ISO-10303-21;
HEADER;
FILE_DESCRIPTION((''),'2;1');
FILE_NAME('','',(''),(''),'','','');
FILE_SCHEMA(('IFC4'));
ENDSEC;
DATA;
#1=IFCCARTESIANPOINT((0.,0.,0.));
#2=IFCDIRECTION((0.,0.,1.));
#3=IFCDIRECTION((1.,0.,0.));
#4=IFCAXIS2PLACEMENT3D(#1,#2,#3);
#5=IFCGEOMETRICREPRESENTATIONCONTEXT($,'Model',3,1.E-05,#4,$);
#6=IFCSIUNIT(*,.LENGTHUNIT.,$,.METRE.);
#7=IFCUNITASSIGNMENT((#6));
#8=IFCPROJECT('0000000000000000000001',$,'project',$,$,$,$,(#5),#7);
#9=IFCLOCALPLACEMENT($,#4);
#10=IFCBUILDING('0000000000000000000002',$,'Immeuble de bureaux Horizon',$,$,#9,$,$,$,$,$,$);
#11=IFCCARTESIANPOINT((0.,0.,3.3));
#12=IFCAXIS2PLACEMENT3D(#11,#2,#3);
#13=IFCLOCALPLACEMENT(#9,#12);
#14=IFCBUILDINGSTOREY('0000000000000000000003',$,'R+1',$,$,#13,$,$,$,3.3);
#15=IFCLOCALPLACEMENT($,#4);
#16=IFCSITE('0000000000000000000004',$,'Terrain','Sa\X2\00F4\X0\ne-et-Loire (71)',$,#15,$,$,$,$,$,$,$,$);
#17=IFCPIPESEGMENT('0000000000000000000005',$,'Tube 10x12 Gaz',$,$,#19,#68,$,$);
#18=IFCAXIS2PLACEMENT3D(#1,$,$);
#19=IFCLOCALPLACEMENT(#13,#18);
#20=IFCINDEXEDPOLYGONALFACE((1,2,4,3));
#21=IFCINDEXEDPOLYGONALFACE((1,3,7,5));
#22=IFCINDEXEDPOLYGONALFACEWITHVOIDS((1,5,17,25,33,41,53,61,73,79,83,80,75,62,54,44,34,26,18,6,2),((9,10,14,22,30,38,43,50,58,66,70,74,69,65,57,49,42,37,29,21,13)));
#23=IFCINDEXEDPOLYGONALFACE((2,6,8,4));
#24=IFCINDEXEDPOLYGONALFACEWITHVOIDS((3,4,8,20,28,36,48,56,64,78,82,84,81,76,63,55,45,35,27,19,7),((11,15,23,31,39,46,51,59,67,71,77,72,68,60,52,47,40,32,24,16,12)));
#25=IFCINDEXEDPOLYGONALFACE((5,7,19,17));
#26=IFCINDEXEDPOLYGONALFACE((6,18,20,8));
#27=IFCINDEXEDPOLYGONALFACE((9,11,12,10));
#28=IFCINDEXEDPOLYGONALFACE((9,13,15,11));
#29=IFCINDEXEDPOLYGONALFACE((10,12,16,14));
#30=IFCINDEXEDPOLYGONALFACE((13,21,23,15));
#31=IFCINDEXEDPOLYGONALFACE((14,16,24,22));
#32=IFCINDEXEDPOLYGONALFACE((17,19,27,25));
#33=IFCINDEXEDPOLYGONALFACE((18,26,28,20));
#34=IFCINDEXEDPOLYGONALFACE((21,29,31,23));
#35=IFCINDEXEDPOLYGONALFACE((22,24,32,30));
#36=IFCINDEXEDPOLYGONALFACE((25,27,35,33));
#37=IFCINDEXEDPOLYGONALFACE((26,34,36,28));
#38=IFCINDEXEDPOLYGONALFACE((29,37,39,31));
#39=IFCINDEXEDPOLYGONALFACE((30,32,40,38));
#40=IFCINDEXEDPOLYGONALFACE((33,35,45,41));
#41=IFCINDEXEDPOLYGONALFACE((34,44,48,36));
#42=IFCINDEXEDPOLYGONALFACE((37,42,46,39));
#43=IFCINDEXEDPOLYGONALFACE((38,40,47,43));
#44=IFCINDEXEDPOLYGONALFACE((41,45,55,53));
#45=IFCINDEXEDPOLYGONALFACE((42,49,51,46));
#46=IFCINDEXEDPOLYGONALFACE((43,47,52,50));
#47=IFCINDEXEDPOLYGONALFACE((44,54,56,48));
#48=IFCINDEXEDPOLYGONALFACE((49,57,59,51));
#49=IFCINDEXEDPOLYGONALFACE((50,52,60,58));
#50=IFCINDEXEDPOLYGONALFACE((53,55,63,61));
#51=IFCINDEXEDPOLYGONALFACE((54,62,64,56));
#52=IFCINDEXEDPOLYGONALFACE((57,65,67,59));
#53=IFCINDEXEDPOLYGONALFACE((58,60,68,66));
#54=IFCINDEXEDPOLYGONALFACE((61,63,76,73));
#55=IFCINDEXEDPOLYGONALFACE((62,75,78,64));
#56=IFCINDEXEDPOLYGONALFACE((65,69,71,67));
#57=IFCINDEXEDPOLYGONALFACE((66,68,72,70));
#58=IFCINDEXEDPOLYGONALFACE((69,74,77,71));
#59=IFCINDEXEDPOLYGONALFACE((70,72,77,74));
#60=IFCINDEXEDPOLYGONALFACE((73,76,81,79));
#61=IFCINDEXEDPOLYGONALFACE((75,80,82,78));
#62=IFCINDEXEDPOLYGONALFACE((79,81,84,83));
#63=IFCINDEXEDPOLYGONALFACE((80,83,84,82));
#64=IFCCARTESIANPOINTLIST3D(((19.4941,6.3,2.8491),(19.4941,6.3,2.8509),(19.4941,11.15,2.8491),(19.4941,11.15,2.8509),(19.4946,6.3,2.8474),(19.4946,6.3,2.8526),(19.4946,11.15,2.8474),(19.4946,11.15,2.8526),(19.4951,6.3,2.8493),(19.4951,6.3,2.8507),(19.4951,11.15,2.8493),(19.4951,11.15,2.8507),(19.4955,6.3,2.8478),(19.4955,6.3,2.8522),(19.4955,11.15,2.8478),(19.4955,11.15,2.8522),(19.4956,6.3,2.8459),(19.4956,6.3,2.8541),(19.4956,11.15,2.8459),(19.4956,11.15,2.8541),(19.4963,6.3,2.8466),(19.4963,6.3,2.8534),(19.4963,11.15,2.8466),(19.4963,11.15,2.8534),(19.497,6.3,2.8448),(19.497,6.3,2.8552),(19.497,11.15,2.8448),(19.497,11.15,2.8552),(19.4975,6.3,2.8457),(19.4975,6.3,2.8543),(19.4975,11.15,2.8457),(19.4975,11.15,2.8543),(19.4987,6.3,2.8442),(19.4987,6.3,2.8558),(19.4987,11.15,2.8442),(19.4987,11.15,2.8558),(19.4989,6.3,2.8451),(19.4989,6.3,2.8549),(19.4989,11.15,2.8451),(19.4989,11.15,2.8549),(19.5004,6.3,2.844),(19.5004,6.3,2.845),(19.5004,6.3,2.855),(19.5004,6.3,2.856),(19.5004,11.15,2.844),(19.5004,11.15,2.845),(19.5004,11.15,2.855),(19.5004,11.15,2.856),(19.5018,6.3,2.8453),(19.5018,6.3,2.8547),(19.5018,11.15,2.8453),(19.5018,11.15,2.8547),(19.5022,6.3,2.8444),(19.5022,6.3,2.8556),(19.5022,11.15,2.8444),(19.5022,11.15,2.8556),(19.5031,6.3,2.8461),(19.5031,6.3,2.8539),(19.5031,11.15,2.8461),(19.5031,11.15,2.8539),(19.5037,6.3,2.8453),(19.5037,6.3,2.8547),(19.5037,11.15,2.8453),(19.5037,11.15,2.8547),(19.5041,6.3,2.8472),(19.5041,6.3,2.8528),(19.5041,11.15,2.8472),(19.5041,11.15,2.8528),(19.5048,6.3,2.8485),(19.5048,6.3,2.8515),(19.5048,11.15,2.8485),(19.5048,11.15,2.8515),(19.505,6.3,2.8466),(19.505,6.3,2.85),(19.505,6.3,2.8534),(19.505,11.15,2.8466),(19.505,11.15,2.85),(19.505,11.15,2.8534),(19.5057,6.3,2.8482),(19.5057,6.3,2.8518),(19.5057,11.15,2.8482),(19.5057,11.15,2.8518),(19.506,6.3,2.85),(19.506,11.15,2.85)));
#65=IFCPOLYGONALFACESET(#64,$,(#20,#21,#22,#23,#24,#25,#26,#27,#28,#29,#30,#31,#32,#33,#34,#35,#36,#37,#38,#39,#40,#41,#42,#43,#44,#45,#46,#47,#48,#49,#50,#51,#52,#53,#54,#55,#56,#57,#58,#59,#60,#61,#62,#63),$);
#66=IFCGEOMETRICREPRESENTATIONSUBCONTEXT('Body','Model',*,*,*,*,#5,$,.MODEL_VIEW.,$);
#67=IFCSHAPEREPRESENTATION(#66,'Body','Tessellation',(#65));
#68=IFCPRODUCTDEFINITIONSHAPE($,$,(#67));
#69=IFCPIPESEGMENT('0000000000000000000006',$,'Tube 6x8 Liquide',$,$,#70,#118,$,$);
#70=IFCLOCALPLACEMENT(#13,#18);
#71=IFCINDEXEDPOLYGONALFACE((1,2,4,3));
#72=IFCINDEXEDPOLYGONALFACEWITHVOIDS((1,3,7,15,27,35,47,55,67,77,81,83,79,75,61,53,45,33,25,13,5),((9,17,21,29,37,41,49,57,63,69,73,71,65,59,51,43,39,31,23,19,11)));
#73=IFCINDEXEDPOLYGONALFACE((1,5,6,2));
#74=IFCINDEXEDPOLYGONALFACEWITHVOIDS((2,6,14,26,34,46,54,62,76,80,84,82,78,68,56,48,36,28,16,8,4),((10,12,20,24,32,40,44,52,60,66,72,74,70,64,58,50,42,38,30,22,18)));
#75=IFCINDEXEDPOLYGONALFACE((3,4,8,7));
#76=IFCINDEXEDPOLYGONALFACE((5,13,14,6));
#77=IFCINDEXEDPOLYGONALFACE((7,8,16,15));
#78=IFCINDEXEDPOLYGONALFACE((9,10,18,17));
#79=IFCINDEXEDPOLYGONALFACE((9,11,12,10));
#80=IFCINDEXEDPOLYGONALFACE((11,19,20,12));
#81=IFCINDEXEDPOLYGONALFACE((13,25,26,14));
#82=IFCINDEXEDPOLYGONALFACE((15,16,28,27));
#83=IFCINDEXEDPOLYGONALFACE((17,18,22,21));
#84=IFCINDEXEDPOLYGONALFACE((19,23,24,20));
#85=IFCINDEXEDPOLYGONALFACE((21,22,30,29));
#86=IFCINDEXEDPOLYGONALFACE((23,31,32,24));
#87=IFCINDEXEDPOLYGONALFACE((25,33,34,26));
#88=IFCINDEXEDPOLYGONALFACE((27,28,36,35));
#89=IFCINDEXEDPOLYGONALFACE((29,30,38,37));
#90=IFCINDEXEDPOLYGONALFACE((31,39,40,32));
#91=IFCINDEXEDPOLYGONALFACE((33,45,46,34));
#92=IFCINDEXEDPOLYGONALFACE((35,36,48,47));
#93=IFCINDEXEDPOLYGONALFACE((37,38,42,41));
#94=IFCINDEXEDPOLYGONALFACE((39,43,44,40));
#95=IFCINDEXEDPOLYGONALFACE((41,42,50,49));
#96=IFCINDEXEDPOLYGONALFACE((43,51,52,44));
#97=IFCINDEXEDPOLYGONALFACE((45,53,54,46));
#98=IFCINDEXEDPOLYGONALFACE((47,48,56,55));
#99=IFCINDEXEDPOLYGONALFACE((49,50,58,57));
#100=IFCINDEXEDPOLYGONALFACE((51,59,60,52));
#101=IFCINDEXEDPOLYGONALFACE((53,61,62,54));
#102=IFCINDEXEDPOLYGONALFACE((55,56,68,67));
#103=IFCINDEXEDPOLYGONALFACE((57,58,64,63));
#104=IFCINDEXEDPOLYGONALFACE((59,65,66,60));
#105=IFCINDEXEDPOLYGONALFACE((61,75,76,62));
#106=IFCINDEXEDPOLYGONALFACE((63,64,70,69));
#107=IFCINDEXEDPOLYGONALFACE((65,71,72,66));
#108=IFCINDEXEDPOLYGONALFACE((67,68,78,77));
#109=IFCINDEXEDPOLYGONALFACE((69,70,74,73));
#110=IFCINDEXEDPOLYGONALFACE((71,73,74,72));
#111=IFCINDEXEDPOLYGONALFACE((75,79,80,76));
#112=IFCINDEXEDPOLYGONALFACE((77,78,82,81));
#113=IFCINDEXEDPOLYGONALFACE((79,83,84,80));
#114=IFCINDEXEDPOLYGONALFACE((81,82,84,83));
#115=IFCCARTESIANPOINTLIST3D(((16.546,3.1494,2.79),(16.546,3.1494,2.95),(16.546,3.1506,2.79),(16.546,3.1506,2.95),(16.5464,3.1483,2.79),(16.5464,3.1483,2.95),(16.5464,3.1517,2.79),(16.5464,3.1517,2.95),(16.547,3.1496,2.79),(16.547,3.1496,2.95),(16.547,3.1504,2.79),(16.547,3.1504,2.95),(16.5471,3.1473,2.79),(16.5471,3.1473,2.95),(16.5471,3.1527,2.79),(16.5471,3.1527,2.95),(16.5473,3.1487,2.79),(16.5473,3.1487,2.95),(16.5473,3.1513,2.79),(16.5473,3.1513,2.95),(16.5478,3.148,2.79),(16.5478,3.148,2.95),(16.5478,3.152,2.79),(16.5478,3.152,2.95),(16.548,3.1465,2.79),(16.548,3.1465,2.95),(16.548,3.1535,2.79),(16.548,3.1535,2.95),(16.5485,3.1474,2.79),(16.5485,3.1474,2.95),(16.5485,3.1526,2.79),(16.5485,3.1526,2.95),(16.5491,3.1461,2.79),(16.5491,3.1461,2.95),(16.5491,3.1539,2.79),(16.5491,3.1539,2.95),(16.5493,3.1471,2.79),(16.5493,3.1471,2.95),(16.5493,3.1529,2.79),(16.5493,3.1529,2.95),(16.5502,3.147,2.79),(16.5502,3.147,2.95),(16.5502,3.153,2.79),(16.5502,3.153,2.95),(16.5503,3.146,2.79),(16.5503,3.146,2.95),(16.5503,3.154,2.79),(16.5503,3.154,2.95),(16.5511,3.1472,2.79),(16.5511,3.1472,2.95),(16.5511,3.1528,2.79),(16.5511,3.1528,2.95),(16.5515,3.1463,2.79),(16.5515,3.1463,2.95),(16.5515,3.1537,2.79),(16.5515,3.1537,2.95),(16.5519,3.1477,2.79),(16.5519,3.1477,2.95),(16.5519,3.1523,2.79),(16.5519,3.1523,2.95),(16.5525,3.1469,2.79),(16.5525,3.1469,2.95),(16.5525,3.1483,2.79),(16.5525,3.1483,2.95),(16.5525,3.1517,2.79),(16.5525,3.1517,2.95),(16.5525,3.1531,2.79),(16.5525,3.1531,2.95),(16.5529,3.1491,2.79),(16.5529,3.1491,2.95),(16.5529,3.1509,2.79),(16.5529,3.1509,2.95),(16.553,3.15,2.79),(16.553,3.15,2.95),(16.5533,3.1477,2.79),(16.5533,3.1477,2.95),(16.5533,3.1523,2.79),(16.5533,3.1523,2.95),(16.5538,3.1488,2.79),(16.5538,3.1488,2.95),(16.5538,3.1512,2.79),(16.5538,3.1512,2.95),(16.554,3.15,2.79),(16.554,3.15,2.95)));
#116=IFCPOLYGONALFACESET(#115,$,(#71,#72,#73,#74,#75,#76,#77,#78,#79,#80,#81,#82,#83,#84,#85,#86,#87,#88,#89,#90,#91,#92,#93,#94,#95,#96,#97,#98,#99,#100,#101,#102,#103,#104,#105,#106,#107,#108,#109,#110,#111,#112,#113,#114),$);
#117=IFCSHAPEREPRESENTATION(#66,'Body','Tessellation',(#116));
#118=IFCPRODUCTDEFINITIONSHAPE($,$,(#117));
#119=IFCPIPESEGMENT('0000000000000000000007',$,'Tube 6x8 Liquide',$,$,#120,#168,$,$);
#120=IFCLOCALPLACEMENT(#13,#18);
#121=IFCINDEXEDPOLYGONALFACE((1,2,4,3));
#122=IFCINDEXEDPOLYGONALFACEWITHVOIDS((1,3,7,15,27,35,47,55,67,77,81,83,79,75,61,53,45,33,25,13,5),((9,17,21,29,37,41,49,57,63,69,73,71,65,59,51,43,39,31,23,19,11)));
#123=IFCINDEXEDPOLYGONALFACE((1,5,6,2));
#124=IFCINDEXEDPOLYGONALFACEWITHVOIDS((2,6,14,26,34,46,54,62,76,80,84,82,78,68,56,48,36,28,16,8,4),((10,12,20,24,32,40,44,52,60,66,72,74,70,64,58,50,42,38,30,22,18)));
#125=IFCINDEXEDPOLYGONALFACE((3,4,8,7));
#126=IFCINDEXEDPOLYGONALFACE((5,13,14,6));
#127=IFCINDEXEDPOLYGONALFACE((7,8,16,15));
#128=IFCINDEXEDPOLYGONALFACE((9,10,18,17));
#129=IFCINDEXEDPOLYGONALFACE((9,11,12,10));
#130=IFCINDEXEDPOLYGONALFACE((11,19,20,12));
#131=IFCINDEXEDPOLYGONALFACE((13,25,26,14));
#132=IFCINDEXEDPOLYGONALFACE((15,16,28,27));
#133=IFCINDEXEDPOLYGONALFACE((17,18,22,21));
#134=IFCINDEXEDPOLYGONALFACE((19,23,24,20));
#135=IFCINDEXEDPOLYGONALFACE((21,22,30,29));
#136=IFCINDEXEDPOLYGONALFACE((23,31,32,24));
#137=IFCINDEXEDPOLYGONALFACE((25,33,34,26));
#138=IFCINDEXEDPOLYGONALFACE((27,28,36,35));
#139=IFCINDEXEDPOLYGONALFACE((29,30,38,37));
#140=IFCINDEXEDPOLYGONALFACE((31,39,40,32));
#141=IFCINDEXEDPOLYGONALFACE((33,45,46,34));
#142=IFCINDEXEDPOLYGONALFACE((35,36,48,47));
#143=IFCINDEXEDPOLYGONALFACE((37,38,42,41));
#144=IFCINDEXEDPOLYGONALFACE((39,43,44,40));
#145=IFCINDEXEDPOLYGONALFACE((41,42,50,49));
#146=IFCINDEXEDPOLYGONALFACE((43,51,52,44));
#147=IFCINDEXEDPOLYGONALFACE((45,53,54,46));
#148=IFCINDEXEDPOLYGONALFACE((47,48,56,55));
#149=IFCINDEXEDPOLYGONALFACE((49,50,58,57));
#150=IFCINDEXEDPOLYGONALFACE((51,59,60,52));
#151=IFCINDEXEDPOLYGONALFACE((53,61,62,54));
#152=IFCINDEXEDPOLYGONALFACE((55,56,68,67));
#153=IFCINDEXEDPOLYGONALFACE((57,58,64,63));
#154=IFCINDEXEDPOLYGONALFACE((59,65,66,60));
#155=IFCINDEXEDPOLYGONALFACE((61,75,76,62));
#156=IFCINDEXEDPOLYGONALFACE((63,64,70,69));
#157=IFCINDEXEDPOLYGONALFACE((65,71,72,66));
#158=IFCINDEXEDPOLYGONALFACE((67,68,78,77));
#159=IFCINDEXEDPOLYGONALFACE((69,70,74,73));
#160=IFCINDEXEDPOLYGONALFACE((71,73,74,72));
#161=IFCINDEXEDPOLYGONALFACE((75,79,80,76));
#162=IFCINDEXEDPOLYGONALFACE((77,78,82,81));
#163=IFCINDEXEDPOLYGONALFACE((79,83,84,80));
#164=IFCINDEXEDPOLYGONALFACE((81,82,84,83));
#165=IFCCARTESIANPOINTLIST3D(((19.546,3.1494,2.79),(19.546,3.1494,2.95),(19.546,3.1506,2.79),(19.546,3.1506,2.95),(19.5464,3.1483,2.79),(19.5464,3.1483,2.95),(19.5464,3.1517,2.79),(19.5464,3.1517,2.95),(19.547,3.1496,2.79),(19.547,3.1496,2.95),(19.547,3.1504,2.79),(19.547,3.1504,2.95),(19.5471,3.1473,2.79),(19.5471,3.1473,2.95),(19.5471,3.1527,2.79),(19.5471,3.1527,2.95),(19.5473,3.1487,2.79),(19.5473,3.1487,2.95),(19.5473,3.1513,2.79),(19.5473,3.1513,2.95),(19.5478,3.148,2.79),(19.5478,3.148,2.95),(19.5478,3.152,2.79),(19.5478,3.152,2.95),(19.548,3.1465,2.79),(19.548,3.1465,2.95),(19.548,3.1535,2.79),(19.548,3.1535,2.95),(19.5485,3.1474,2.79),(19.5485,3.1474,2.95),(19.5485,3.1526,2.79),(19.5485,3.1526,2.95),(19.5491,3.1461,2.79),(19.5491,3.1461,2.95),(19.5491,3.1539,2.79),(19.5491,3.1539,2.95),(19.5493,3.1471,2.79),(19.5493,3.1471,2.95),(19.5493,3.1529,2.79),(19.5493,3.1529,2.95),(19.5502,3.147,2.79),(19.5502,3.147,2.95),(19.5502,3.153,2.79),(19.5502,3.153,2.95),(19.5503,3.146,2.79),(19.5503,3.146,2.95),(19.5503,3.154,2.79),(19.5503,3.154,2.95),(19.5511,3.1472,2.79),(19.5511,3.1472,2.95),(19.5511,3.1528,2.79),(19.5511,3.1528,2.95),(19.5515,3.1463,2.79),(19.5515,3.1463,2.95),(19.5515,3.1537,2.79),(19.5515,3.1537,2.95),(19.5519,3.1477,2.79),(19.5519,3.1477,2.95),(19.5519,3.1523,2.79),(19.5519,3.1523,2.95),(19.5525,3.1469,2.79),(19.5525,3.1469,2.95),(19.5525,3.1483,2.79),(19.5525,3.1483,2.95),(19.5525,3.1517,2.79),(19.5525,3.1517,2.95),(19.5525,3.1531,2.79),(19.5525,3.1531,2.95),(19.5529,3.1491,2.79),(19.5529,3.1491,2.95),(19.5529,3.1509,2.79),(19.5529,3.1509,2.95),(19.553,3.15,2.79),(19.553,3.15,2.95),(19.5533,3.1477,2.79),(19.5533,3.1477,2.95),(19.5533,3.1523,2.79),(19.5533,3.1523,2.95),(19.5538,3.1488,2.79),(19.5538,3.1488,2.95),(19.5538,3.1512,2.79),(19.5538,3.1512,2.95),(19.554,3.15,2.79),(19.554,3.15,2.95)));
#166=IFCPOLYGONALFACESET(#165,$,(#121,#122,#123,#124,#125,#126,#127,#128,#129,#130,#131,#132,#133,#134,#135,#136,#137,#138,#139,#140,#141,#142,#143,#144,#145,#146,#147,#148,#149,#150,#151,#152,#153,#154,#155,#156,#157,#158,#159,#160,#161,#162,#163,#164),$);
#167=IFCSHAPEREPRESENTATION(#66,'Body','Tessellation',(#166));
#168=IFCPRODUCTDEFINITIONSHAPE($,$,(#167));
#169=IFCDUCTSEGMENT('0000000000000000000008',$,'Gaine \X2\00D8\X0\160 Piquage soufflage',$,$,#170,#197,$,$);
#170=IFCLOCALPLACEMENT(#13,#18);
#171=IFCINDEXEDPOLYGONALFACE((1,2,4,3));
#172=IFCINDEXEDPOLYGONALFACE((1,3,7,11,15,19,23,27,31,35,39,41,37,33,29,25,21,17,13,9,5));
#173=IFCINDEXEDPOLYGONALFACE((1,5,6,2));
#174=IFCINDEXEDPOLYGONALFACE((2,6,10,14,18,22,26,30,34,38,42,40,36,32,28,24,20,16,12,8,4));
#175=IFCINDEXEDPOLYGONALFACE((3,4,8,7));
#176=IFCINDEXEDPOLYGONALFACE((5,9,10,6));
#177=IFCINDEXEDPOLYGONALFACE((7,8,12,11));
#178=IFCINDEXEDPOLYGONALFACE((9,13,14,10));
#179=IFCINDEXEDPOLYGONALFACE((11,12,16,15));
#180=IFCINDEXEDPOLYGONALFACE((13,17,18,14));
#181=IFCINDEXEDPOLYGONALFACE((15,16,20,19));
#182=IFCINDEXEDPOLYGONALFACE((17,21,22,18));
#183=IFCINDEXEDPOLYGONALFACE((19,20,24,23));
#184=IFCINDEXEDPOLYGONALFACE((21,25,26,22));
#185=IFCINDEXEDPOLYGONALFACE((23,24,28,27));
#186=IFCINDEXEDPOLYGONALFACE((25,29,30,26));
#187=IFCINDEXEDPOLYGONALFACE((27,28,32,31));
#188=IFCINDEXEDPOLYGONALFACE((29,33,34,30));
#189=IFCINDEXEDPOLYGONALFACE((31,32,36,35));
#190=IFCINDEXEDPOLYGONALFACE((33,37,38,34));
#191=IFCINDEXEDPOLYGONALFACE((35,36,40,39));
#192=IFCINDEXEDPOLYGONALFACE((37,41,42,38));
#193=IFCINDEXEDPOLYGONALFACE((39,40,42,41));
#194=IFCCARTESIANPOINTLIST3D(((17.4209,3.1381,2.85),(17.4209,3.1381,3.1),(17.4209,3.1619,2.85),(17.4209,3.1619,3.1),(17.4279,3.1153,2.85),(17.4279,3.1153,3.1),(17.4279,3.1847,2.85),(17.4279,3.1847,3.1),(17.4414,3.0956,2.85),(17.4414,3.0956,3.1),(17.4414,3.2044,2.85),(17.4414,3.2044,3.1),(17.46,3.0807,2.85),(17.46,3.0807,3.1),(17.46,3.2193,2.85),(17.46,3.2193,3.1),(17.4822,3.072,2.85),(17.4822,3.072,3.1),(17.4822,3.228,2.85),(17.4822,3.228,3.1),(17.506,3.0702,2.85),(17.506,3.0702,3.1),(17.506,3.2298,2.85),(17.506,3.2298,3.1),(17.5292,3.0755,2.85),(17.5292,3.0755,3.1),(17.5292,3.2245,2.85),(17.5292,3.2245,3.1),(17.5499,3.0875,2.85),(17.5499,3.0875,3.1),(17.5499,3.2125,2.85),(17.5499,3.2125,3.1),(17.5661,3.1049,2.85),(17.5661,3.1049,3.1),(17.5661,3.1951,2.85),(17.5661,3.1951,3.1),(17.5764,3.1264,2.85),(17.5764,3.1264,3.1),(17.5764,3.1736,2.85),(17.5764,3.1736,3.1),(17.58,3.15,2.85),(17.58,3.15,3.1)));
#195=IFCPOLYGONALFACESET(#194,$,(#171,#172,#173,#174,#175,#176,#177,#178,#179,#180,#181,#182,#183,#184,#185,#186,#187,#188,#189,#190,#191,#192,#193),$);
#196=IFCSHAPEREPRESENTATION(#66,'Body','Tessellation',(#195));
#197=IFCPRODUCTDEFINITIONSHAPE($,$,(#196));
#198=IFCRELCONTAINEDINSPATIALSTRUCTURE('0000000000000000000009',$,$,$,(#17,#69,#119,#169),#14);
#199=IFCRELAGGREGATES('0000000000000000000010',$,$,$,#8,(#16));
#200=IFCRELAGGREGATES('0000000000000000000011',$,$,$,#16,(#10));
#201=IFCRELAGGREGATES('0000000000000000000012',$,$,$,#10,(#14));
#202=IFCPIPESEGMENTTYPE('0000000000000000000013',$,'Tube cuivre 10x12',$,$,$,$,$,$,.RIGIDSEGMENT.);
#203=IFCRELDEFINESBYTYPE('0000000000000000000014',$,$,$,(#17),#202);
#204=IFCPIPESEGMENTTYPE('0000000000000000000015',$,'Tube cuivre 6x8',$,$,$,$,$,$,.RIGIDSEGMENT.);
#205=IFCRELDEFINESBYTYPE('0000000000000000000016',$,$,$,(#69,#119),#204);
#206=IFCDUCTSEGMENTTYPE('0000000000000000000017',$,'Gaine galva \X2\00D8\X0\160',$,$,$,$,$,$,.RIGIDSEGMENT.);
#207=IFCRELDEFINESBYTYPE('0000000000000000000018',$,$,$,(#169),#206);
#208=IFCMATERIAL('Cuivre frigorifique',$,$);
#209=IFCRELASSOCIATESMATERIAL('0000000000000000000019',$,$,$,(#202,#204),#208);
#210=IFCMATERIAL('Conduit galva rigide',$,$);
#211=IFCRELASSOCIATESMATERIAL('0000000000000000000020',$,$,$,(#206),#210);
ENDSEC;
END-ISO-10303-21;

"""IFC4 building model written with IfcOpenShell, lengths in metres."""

from ifc_helpers import new_model, si_unit, frame, origin_with_axes, place, context, subcontext, project, spatial, circle, hollow_circle, extrude, material, type_object, element, save


model = new_model("IFC4")

# Units and contexts
model_context = context("Model", 3, precision=1e-05, world=origin_with_axes())
body_context = subcontext(model_context, "Body", "Model", "MODEL_VIEW")
ifc_project = project(units=[si_unit("LENGTHUNIT", "METRE")], contexts=[model_context])

# Site, building, storey
site_placement = place(None, origin_with_axes())
site = spatial("IfcSite", under=ifc_project, at=site_placement, Name="Terrain", Description="Saône-et-Loire (71)")
building_placement = place(None, origin_with_axes())
building = spatial("IfcBuilding", under=site, at=building_placement, Name="Immeuble de bureaux Horizon")
storey_placement = place(building_placement, frame((0.0, 0.0, 3.3), z_axis=(0.0, 0.0, 1.0), x_axis=(1.0, 0.0, 0.0)))
storey = spatial("IfcBuildingStorey", under=building, at=storey_placement, Name="R+1", Elevation=3.3)

# Pipe segments
ifc_material_1 = material(Name="Cuivre frigorifique")
pipe_segment_type_1 = type_object("IfcPipeSegmentType", Name="Tube cuivre 10x12", PredefinedType="RIGIDSEGMENT", material=ifc_material_1)
for number, where, z_axis, x_axis, name in (
    (1, (19.5, 6.3, 2.85), (0.0, 1.0, 0.0), (1.0, 0.0, 0.0), "Tube 10x12 Gaz"),
):
    element("IfcPipeSegment", number, at=place(storey_placement, frame(where, z_axis=z_axis, x_axis=x_axis)), inside=storey, type_object=pipe_segment_type_1, Name=name, context=body_context, shape_type="SweptSolid", body=[
        extrude(hollow_circle(Radius=0.006, WallThickness=0.001), origin_with_axes(), (0.0, 0.0, 1.0), 4.85),
    ])
pipe_segment_type_2 = type_object("IfcPipeSegmentType", Name="Tube cuivre 6x8", PredefinedType="RIGIDSEGMENT", material=ifc_material_1)
for number, where, z_axis, x_axis, name in (
    (2, (16.55, 3.15, 2.79), (0.0, 0.0, 1.0), (1.0, 0.0, 0.0), "Tube 6x8 Liquide"),
    (3, (19.55, 3.15, 2.79), (0.0, 0.0, 1.0), (1.0, 0.0, 0.0), "Tube 6x8 Liquide"),
):
    element("IfcPipeSegment", number, at=place(storey_placement, frame(where, z_axis=z_axis, x_axis=x_axis)), inside=storey, type_object=pipe_segment_type_2, Name=name, context=body_context, shape_type="SweptSolid", body=[
        extrude(hollow_circle(Radius=0.004, WallThickness=0.001), origin_with_axes(), (0.0, 0.0, 1.0), 0.16),
    ])

# Duct segment
ifc_material_2 = material(Name="Conduit galva rigide")
duct_segment_type = type_object("IfcDuctSegmentType", Name="Gaine galva Ø160", PredefinedType="RIGIDSEGMENT", material=ifc_material_2)
duct_segment_1_placement = place(storey_placement, frame((17.5, 3.15, 3.1), z_axis=(0.0, 0.0, -1.0), x_axis=(1.0, 0.0, 0.0)))
element("IfcDuctSegment", 4, at=duct_segment_1_placement, inside=storey, type_object=duct_segment_type, Name="Gaine Ø160 Piquage soufflage", context=body_context, shape_type="SweptSolid", body=[
    extrude(circle(Radius=0.08), origin_with_axes(), (0.0, 0.0, 1.0), 0.25),
])

save(model, "model.ifc")
